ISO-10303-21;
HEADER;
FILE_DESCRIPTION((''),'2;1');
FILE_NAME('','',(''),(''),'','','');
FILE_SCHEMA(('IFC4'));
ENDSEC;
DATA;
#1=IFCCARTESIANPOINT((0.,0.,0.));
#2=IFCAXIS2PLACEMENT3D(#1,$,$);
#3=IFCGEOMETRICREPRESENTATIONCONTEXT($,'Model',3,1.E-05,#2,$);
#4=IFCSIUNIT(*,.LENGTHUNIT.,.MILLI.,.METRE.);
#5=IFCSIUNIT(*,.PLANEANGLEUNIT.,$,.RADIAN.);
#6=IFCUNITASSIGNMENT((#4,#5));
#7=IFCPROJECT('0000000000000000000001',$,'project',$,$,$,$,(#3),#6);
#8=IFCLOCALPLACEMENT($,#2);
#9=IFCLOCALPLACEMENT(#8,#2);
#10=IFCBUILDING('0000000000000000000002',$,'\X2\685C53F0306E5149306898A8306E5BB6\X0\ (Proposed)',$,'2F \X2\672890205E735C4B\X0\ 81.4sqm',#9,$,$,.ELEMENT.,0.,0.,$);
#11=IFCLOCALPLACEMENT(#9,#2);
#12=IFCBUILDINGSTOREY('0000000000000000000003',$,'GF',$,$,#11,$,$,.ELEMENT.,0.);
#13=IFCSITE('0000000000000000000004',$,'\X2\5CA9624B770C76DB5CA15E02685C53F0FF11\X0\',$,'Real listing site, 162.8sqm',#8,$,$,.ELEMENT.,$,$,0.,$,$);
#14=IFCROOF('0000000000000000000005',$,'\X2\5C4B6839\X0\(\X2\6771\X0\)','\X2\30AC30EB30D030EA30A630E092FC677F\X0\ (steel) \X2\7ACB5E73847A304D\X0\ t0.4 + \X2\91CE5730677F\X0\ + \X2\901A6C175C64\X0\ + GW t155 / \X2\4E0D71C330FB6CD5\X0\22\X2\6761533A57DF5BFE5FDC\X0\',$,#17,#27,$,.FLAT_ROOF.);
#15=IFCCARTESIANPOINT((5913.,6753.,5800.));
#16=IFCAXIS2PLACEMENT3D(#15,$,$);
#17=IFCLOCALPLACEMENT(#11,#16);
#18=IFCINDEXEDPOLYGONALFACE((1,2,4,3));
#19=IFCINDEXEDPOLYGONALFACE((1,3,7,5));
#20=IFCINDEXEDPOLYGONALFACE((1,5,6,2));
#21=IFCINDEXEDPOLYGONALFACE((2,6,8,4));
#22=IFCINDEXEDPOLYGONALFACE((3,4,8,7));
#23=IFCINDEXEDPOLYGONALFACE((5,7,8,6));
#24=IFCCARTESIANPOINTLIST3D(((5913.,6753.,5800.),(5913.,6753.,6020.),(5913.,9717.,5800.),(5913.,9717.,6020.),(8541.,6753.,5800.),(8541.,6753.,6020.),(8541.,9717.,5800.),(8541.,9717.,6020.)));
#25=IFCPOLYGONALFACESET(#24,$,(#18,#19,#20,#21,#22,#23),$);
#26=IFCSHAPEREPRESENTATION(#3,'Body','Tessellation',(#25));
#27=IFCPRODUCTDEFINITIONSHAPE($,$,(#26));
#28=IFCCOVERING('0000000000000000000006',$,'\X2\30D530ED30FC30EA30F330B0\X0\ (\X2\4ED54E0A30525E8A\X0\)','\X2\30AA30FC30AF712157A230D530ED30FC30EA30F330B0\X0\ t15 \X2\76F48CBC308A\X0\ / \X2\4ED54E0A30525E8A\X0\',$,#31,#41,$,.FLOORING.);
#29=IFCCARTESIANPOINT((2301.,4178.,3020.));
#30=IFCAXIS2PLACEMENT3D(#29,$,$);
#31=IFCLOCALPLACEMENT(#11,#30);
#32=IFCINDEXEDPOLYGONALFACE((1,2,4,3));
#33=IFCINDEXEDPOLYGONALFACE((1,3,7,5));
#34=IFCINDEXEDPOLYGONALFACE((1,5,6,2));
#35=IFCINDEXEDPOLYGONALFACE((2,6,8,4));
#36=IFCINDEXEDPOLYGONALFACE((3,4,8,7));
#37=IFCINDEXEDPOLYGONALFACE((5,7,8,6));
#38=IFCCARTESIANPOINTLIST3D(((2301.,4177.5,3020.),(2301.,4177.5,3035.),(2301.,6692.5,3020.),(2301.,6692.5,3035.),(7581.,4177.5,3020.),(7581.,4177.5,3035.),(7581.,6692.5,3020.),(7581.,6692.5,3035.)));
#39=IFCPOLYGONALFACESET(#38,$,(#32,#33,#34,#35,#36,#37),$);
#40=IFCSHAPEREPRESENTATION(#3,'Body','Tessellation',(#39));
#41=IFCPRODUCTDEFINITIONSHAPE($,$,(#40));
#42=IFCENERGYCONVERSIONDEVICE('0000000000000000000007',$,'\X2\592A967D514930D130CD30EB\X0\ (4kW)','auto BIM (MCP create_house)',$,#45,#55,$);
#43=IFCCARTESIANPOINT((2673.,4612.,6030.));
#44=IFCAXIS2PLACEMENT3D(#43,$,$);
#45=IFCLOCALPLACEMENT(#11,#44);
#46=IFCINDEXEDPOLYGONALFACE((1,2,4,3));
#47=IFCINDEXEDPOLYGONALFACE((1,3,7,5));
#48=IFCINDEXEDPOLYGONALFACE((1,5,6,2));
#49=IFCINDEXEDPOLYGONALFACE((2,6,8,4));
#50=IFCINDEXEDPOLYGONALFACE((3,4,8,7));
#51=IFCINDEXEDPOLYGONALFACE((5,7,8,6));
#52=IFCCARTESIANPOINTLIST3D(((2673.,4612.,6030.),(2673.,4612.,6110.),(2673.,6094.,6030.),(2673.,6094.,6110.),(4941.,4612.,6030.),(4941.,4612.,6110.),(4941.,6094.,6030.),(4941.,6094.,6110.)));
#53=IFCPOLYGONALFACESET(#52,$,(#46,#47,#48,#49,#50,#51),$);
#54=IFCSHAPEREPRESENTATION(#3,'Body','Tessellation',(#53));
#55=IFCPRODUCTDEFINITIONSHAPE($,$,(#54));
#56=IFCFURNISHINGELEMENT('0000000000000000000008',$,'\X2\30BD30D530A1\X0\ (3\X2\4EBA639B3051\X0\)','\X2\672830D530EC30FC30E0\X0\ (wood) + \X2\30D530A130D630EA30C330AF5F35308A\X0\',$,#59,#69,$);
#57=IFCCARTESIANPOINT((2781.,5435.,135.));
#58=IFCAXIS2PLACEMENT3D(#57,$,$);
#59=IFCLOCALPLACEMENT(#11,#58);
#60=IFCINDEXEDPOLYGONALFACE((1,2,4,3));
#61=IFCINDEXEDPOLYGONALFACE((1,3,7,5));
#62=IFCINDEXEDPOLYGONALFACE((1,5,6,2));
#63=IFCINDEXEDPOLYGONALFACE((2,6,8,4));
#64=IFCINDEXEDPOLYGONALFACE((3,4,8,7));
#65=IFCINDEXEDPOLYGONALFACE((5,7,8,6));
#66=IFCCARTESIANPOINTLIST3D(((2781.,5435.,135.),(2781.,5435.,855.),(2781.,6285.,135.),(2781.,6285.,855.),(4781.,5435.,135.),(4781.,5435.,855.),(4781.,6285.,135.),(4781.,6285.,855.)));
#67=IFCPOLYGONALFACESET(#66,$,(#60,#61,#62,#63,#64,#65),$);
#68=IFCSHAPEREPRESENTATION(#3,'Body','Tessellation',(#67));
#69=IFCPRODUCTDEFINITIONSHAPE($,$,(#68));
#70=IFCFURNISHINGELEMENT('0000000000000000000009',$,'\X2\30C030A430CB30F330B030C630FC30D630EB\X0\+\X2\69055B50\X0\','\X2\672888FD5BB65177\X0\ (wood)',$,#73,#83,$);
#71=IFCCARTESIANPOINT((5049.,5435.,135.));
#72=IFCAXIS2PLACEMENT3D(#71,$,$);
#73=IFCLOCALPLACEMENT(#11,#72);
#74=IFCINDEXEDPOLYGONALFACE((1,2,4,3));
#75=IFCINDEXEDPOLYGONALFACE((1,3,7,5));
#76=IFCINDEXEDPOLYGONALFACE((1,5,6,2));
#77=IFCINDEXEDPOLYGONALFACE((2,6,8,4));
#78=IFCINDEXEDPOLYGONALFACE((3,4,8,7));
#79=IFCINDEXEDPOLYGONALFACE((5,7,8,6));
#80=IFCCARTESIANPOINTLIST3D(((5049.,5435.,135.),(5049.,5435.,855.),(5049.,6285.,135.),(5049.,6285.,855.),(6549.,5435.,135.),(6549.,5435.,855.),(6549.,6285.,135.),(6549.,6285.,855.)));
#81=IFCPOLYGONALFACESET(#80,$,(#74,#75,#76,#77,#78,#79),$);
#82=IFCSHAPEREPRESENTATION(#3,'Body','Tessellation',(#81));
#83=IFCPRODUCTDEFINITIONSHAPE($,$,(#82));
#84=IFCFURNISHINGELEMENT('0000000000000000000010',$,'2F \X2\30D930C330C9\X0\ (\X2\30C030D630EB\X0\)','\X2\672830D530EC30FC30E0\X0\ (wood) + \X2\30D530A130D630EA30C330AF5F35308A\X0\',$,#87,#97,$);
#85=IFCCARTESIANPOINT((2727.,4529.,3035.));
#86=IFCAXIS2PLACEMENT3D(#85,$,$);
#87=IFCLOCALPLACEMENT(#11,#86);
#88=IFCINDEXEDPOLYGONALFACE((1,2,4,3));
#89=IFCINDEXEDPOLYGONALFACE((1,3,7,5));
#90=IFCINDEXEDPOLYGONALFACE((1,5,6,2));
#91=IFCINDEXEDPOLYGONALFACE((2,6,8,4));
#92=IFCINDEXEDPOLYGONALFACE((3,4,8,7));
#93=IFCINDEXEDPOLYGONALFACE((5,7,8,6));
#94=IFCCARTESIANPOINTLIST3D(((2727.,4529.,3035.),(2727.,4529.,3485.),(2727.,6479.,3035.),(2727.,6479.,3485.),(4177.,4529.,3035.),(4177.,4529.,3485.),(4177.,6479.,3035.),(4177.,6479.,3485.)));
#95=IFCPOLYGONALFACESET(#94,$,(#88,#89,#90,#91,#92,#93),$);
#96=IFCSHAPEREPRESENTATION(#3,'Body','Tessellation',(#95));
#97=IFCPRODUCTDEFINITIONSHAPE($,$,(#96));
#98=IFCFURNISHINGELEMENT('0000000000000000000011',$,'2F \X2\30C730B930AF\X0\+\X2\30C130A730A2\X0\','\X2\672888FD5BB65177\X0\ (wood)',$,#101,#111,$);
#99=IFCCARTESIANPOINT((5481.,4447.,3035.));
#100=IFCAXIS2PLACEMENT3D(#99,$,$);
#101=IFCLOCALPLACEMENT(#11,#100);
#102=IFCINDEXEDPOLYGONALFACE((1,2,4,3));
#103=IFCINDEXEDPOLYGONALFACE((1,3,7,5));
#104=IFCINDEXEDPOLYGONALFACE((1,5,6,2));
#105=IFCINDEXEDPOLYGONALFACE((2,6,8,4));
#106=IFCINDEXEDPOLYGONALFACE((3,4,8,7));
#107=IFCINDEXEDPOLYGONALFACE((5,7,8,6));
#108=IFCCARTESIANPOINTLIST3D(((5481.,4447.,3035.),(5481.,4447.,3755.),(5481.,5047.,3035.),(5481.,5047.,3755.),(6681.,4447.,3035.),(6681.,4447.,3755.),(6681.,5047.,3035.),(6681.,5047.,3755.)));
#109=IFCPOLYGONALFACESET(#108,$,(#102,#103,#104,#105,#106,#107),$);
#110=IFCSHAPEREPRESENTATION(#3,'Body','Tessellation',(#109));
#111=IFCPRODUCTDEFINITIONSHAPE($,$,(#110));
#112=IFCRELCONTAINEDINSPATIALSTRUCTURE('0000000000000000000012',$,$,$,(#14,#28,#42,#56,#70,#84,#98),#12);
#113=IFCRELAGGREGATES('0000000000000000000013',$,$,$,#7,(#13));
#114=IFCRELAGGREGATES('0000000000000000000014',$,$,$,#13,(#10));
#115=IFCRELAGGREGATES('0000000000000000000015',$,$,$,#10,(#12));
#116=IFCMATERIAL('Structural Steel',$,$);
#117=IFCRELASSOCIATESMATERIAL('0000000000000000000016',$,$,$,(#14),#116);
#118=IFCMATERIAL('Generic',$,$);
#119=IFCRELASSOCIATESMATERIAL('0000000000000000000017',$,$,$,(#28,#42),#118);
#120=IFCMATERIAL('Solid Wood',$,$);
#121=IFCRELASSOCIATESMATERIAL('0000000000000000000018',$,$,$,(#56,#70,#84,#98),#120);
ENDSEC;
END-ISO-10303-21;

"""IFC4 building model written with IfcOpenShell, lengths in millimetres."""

from ifc_helpers import new_model, si_unit, frame, frame_2d, origin, place, context, project, spatial, rectangle, extrude, material, element, save


model = new_model("IFC4")

# Units and contexts
model_context = context("Model", 3, precision=1e-05, world=origin())
ifc_project = project(units=[si_unit("LENGTHUNIT", "METRE", prefix="MILLI"), si_unit("PLANEANGLEUNIT", "RADIAN")], contexts=[model_context])

# Site, building, storey
site_placement = place(None, origin())
site = spatial("IfcSite", under=ifc_project, at=site_placement, Name="岩手県盛岡市桜台１", ObjectType="Real listing site, 162.8sqm", CompositionType="ELEMENT", RefElevation=0.0)
building_placement = place(site_placement, origin())
building = spatial("IfcBuilding", under=site, at=building_placement, Name="桜台の光と風の家 (Proposed)", ObjectType="2F 木造平屋 81.4sqm", CompositionType="ELEMENT", ElevationOfRefHeight=0.0, ElevationOfTerrain=0.0)
storey_placement = place(building_placement, origin())
storey = spatial("IfcBuildingStorey", under=building, at=storey_placement, Name="GF", CompositionType="ELEMENT", Elevation=0.0)

# Shared definitions
ifc_material_1 = material(Name="Solid Wood")

# Roof
ifc_material_2 = material(Name="Structural Steel")
roof_1_placement = place(storey_placement, frame((5913.0, 6753.0, 5800.0)))
element("IfcRoof", 1, at=roof_1_placement, inside=storey, material=ifc_material_2, Name="屋根(東)", Description="ガルバリウム鋼板 (steel) 立平葺き t0.4 + 野地板 + 通気層 + GW t155 / 不燃・法22条区域対応", PredefinedType="FLAT_ROOF", context=model_context, shape_type="SweptSolid", body=[
    extrude(rectangle(XDim=2628.0, YDim=2964.0, at=frame_2d((1314.0, 1482.0))), frame((5913.0, 6753.0, 5800.0)), (0.0, 0.0, 1.0), 220.0),
])

# Covering
ifc_material_3 = material(Name="Generic")
covering_placement = place(storey_placement, frame((2301.0, 4178.0, 3020.0)))
element("IfcCovering", 2, at=covering_placement, inside=storey, material=ifc_material_3, Name="フローリング (仕上げ床)", Description="オーク無垢フローリング t15 直貼り / 仕上げ床", PredefinedType="FLOORING", context=model_context, shape_type="SweptSolid", body=[
    extrude(rectangle(XDim=5280.0, YDim=2515.0, at=frame_2d((2640.0, 1257.0))), frame((2301.0, 4178.0, 3020.0)), (0.0, 0.0, 1.0), 15.0),
])

# Energy conversion device
energy_conversion_device_placement = place(storey_placement, frame((2673.0, 4612.0, 6030.0)))
element("IfcEnergyConversionDevice", 3, at=energy_conversion_device_placement, inside=storey, material=ifc_material_3, Name="太陽光パネル (4kW)", Description="auto BIM (MCP create_house)", context=model_context, shape_type="SweptSolid", body=[
    extrude(rectangle(XDim=2268.0, YDim=1482.0, at=frame_2d((1134.0, 741.0))), frame((2673.0, 4612.0, 6030.0)), (0.0, 0.0, 1.0), 80.0),
])

# Furnishing elements
furnishing_1_placement = place(storey_placement, frame((2781.0, 5435.0, 135.0)))
element("IfcFurnishingElement", 4, at=furnishing_1_placement, inside=storey, material=ifc_material_1, Name="ソファ (3人掛け)", Description="木フレーム (wood) + ファブリック張り", context=model_context, shape_type="SweptSolid", body=[
    extrude(rectangle(XDim=2000.0, YDim=850.0, at=frame_2d((1000.0, 425.0))), frame((2781.0, 5435.0, 135.0)), (0.0, 0.0, 1.0), 720.0),
])
furnishing_2_placement = place(storey_placement, frame((5049.0, 5435.0, 135.0)))
element("IfcFurnishingElement", 5, at=furnishing_2_placement, inside=storey, material=ifc_material_1, Name="ダイニングテーブル+椅子", Description="木製家具 (wood)", context=model_context, shape_type="SweptSolid", body=[
    extrude(rectangle(XDim=1500.0, YDim=850.0, at=frame_2d((750.0, 425.0))), frame((5049.0, 5435.0, 135.0)), (0.0, 0.0, 1.0), 720.0),
])
furnishing_3_placement = place(storey_placement, frame((2727.0, 4529.0, 3035.0)))
element("IfcFurnishingElement", 6, at=furnishing_3_placement, inside=storey, material=ifc_material_1, Name="2F ベッド (ダブル)", Description="木フレーム (wood) + ファブリック張り", context=model_context, shape_type="SweptSolid", body=[
    extrude(rectangle(XDim=1450.0, YDim=1950.0, at=frame_2d((725.0, 975.0))), frame((2727.0, 4529.0, 3035.0)), (0.0, 0.0, 1.0), 450.0),
])
furnishing_4_placement = place(storey_placement, frame((5481.0, 4447.0, 3035.0)))
element("IfcFurnishingElement", 7, at=furnishing_4_placement, inside=storey, material=ifc_material_1, Name="2F デスク+チェア", Description="木製家具 (wood)", context=model_context, shape_type="SweptSolid", body=[
    extrude(rectangle(XDim=1200.0, YDim=600.0, at=frame_2d((600.0, 300.0))), frame((5481.0, 4447.0, 3035.0)), (0.0, 0.0, 1.0), 720.0),
])

save(model, "model.ifc")
